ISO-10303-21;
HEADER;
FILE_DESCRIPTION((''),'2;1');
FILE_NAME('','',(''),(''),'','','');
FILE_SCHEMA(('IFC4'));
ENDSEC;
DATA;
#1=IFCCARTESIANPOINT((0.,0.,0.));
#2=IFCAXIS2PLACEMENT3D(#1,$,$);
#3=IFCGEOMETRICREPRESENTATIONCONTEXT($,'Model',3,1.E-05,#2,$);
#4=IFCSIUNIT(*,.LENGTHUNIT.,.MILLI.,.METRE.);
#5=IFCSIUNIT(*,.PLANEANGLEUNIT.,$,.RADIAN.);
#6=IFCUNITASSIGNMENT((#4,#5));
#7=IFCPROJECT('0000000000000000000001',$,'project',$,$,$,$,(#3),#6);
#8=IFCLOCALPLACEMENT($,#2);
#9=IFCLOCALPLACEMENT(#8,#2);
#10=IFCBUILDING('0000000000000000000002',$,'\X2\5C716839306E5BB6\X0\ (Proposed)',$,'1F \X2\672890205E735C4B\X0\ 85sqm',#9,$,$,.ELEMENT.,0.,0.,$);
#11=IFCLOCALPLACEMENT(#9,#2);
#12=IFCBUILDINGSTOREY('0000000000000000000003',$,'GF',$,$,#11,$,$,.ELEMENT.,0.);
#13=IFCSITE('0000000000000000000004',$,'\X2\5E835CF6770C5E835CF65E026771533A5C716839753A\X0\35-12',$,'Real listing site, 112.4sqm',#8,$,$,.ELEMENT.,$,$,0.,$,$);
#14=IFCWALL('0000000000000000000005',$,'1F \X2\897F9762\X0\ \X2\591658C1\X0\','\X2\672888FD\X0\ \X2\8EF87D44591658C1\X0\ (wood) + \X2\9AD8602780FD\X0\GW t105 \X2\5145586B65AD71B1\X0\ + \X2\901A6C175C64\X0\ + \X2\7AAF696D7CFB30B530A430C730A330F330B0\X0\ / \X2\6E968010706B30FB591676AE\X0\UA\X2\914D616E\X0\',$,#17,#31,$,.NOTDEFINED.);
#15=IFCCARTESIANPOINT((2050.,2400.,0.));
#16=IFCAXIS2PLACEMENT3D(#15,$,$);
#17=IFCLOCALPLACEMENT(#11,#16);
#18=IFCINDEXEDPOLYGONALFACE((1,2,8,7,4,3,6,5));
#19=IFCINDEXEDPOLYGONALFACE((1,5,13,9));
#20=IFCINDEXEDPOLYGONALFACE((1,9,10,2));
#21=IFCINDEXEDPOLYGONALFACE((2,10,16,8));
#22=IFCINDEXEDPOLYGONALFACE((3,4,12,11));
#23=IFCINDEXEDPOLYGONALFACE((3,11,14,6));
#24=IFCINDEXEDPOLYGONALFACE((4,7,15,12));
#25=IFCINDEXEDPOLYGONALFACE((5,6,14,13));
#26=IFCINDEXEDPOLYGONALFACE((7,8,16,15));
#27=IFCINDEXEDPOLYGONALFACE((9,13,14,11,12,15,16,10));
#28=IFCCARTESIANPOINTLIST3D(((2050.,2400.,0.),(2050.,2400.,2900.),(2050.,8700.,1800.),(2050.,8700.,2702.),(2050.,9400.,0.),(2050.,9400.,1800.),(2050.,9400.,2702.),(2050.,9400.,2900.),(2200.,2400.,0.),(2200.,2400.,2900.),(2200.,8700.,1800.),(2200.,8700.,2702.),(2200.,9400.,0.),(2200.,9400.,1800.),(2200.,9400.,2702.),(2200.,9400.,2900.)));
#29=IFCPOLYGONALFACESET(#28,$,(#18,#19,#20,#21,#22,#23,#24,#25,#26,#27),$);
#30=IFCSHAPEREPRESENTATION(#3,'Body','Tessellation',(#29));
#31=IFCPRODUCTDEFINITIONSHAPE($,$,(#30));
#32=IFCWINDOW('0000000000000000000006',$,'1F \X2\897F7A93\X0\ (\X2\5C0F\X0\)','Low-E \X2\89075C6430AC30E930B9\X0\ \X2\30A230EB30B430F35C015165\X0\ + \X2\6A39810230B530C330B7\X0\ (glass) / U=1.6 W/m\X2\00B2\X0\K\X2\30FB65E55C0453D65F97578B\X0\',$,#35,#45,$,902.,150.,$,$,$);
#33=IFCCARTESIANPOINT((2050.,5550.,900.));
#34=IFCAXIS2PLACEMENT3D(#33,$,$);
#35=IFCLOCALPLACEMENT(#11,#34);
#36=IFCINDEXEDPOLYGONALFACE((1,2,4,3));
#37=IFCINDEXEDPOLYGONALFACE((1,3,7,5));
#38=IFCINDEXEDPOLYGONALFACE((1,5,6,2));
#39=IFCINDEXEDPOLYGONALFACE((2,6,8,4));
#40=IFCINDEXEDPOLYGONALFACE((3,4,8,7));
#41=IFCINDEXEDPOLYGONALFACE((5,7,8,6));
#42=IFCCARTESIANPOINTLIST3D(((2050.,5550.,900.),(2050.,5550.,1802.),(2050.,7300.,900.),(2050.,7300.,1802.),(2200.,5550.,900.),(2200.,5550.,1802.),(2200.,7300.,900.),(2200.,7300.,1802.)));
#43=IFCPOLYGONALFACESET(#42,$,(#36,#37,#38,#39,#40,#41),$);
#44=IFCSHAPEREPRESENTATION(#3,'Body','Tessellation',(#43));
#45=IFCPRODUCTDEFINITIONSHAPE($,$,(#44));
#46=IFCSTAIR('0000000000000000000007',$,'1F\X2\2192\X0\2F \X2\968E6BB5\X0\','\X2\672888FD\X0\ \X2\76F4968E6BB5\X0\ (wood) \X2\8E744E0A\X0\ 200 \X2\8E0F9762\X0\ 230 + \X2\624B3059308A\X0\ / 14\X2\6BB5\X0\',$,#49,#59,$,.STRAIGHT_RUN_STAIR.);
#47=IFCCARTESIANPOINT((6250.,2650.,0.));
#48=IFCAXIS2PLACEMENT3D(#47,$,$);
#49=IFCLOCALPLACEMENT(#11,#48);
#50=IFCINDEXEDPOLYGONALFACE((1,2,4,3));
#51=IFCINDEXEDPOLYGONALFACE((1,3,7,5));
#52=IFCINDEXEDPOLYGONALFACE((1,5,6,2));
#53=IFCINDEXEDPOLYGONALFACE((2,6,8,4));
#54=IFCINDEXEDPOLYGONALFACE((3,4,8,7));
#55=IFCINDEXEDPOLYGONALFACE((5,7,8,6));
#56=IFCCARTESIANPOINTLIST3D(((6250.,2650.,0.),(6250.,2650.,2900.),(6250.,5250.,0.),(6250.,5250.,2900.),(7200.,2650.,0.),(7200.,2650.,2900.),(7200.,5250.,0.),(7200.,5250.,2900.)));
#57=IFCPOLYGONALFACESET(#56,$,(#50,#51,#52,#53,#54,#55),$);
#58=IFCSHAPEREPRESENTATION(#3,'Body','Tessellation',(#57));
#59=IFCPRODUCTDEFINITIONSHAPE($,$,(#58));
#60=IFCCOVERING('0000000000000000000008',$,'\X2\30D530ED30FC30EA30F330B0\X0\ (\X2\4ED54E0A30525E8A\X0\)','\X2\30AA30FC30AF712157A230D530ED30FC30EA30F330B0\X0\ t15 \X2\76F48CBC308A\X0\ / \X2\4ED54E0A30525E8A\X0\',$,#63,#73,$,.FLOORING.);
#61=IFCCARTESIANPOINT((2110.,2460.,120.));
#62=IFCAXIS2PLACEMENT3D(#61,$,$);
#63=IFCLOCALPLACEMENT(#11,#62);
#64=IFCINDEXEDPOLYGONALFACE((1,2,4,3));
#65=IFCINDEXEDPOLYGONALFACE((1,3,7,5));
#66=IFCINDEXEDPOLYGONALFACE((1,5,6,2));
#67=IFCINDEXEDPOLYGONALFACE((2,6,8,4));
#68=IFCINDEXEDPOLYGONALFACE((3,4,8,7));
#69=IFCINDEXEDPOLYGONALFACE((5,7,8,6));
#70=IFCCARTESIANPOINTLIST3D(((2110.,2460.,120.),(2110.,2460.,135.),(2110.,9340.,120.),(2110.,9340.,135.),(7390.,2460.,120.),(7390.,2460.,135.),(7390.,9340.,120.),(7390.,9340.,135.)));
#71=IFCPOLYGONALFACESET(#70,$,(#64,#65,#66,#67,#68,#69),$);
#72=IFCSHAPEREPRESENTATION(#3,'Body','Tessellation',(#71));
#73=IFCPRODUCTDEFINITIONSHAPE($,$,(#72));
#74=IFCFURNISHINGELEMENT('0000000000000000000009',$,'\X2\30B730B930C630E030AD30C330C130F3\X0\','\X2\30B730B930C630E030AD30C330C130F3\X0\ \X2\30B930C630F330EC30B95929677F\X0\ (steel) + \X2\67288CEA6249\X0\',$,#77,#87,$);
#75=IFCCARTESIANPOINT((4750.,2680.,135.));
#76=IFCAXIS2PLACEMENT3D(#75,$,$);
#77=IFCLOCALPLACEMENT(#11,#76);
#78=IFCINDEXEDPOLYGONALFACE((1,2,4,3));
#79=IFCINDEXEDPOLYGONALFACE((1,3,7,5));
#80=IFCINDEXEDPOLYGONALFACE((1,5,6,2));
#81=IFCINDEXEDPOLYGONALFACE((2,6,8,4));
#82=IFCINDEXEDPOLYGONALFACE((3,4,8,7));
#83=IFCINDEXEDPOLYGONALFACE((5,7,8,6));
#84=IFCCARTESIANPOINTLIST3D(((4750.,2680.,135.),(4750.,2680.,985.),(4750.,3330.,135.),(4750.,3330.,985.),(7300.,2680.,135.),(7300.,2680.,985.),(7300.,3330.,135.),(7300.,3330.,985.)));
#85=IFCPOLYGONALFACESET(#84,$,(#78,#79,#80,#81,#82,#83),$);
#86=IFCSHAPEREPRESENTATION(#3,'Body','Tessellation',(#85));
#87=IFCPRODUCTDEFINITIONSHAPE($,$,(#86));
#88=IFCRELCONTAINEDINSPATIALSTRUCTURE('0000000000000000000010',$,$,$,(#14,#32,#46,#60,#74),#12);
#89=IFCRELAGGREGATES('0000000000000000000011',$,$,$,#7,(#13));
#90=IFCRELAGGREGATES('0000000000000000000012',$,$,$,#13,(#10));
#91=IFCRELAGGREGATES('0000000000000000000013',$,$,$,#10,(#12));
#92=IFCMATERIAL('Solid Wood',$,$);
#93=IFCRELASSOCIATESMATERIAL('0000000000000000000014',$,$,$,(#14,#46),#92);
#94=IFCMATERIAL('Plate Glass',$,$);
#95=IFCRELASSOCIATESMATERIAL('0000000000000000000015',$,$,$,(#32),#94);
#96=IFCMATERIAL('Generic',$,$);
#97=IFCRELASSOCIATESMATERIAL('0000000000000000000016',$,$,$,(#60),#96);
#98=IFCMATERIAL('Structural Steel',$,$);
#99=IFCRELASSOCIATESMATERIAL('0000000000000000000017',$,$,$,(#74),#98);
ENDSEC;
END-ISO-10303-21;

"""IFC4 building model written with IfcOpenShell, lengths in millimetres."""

from ifc_helpers import new_model, si_unit, frame, frame_2d, origin, place, context, project, spatial, rectangle, extrude, material, element, fill, save


model = new_model("IFC4")

# Units and contexts
model_context = context("Model", 3, precision=1e-05, world=origin())
ifc_project = project(units=[si_unit("LENGTHUNIT", "METRE", prefix="MILLI"), si_unit("PLANEANGLEUNIT", "RADIAN")], contexts=[model_context])

# Site, building, storey
site_placement = place(None, origin())
site = spatial("IfcSite", under=ifc_project, at=site_placement, Name="広島県広島市東区山根町35-12", ObjectType="Real listing site, 112.4sqm", CompositionType="ELEMENT", RefElevation=0.0)
building_placement = place(site_placement, origin())
building = spatial("IfcBuilding", under=site, at=building_placement, Name="山根の家 (Proposed)", ObjectType="1F 木造平屋 85sqm", CompositionType="ELEMENT", ElevationOfRefHeight=0.0, ElevationOfTerrain=0.0)
storey_placement = place(building_placement, origin())
storey = spatial("IfcBuildingStorey", under=building, at=storey_placement, Name="GF", CompositionType="ELEMENT", Elevation=0.0)

# Shared definitions
ifc_material_1 = material(Name="Solid Wood")
ifc_material_2 = material(Name="Generic")

# Shared definitions
ifc_material_3 = material(Name="Plate Glass")

# Wall, opening, window
wall_1_placement = place(storey_placement, frame((2050.0, 2400.0, 0.0)))
wall_1 = element("IfcWall", 1, at=wall_1_placement, inside=storey, material=ifc_material_1, Name="1F 西面 外壁", Description="木製 軸組外壁 (wood) + 高性能GW t105 充填断熱 + 通気層 + 窯業系サイディング / 準耐火・外皮UA配慮", PredefinedType="NOTDEFINED", context=model_context, shape_type="SweptSolid", body=[
    extrude(rectangle(XDim=150.0, YDim=7000.0, at=frame_2d((75.0, 3500.0))), frame((2050.0, 2400.0, 0.0)), (0.0, 0.0, 1.0), 2900.0),
])
opening_1_placement = place(storey_placement, frame((2050.0, 5550.0, 900.0)))
opening_1 = element("IfcOpeningElement", 2, at=opening_1_placement, cuts=wall_1, PredefinedType="NOTDEFINED", context=model_context, shape_type="SweptSolid", body=[
    extrude(rectangle(XDim=150.0, YDim=1750.0, at=frame_2d((75.0, 875.0))), frame((2050.0, 5550.0, 900.0)), (0.0, 0.0, 1.0), 902.0),
])
window_1_placement = place(storey_placement, frame((2050.0, 5550.0, 900.0)))
window_1 = element("IfcWindow", 3, at=window_1_placement, inside=storey, material=ifc_material_3, Name="1F 西窓 (小)", Description="Low-E 複層ガラス アルゴン封入 + 樹脂サッシ (glass) / U=1.6 W/m²K・日射取得型", OverallHeight=902.0, OverallWidth=150.0, context=model_context, shape_type="SweptSolid", body=[
    extrude(rectangle(XDim=150.0, YDim=1750.0, at=frame_2d((75.0, 875.0))), frame((2050.0, 5550.0, 900.0)), (0.0, 0.0, 1.0), 902.0),
])
fill(opening_1, window_1)

# Stair
stair_placement = place(storey_placement, frame((6250.0, 2650.0, 0.0)))
element("IfcStair", 4, at=stair_placement, inside=storey, material=ifc_material_1, Name="1F→2F 階段", Description="木製 直階段 (wood) 蹴上 200 踏面 230 + 手すり / 14段", PredefinedType="STRAIGHT_RUN_STAIR", context=model_context, shape_type="SweptSolid", body=[
    extrude(rectangle(XDim=950.0, YDim=2600.0, at=frame_2d((475.0, 1300.0))), frame((6250.0, 2650.0, 0.0)), (0.0, 0.0, 1.0), 2900.0),
])

# Covering
covering_placement = place(storey_placement, frame((2110.0, 2460.0, 120.0)))
element("IfcCovering", 5, at=covering_placement, inside=storey, material=ifc_material_2, Name="フローリング (仕上げ床)", Description="オーク無垢フローリング t15 直貼り / 仕上げ床", PredefinedType="FLOORING", context=model_context, shape_type="SweptSolid", body=[
    extrude(rectangle(XDim=5280.0, YDim=6880.0, at=frame_2d((2640.0, 3440.0))), frame((2110.0, 2460.0, 120.0)), (0.0, 0.0, 1.0), 15.0),
])

# Furnishing element
ifc_material_4 = material(Name="Structural Steel")
furnishing_placement = place(storey_placement, frame((4750.0, 2680.0, 135.0)))
element("IfcFurnishingElement", 6, at=furnishing_placement, inside=storey, material=ifc_material_4, Name="システムキッチン", Description="システムキッチン ステンレス天板 (steel) + 木質扉", context=model_context, shape_type="SweptSolid", body=[
    extrude(rectangle(XDim=2550.0, YDim=650.0, at=frame_2d((1275.0, 325.0))), frame((4750.0, 2680.0, 135.0)), (0.0, 0.0, 1.0), 850.0),
])

save(model, "model.ifc")
